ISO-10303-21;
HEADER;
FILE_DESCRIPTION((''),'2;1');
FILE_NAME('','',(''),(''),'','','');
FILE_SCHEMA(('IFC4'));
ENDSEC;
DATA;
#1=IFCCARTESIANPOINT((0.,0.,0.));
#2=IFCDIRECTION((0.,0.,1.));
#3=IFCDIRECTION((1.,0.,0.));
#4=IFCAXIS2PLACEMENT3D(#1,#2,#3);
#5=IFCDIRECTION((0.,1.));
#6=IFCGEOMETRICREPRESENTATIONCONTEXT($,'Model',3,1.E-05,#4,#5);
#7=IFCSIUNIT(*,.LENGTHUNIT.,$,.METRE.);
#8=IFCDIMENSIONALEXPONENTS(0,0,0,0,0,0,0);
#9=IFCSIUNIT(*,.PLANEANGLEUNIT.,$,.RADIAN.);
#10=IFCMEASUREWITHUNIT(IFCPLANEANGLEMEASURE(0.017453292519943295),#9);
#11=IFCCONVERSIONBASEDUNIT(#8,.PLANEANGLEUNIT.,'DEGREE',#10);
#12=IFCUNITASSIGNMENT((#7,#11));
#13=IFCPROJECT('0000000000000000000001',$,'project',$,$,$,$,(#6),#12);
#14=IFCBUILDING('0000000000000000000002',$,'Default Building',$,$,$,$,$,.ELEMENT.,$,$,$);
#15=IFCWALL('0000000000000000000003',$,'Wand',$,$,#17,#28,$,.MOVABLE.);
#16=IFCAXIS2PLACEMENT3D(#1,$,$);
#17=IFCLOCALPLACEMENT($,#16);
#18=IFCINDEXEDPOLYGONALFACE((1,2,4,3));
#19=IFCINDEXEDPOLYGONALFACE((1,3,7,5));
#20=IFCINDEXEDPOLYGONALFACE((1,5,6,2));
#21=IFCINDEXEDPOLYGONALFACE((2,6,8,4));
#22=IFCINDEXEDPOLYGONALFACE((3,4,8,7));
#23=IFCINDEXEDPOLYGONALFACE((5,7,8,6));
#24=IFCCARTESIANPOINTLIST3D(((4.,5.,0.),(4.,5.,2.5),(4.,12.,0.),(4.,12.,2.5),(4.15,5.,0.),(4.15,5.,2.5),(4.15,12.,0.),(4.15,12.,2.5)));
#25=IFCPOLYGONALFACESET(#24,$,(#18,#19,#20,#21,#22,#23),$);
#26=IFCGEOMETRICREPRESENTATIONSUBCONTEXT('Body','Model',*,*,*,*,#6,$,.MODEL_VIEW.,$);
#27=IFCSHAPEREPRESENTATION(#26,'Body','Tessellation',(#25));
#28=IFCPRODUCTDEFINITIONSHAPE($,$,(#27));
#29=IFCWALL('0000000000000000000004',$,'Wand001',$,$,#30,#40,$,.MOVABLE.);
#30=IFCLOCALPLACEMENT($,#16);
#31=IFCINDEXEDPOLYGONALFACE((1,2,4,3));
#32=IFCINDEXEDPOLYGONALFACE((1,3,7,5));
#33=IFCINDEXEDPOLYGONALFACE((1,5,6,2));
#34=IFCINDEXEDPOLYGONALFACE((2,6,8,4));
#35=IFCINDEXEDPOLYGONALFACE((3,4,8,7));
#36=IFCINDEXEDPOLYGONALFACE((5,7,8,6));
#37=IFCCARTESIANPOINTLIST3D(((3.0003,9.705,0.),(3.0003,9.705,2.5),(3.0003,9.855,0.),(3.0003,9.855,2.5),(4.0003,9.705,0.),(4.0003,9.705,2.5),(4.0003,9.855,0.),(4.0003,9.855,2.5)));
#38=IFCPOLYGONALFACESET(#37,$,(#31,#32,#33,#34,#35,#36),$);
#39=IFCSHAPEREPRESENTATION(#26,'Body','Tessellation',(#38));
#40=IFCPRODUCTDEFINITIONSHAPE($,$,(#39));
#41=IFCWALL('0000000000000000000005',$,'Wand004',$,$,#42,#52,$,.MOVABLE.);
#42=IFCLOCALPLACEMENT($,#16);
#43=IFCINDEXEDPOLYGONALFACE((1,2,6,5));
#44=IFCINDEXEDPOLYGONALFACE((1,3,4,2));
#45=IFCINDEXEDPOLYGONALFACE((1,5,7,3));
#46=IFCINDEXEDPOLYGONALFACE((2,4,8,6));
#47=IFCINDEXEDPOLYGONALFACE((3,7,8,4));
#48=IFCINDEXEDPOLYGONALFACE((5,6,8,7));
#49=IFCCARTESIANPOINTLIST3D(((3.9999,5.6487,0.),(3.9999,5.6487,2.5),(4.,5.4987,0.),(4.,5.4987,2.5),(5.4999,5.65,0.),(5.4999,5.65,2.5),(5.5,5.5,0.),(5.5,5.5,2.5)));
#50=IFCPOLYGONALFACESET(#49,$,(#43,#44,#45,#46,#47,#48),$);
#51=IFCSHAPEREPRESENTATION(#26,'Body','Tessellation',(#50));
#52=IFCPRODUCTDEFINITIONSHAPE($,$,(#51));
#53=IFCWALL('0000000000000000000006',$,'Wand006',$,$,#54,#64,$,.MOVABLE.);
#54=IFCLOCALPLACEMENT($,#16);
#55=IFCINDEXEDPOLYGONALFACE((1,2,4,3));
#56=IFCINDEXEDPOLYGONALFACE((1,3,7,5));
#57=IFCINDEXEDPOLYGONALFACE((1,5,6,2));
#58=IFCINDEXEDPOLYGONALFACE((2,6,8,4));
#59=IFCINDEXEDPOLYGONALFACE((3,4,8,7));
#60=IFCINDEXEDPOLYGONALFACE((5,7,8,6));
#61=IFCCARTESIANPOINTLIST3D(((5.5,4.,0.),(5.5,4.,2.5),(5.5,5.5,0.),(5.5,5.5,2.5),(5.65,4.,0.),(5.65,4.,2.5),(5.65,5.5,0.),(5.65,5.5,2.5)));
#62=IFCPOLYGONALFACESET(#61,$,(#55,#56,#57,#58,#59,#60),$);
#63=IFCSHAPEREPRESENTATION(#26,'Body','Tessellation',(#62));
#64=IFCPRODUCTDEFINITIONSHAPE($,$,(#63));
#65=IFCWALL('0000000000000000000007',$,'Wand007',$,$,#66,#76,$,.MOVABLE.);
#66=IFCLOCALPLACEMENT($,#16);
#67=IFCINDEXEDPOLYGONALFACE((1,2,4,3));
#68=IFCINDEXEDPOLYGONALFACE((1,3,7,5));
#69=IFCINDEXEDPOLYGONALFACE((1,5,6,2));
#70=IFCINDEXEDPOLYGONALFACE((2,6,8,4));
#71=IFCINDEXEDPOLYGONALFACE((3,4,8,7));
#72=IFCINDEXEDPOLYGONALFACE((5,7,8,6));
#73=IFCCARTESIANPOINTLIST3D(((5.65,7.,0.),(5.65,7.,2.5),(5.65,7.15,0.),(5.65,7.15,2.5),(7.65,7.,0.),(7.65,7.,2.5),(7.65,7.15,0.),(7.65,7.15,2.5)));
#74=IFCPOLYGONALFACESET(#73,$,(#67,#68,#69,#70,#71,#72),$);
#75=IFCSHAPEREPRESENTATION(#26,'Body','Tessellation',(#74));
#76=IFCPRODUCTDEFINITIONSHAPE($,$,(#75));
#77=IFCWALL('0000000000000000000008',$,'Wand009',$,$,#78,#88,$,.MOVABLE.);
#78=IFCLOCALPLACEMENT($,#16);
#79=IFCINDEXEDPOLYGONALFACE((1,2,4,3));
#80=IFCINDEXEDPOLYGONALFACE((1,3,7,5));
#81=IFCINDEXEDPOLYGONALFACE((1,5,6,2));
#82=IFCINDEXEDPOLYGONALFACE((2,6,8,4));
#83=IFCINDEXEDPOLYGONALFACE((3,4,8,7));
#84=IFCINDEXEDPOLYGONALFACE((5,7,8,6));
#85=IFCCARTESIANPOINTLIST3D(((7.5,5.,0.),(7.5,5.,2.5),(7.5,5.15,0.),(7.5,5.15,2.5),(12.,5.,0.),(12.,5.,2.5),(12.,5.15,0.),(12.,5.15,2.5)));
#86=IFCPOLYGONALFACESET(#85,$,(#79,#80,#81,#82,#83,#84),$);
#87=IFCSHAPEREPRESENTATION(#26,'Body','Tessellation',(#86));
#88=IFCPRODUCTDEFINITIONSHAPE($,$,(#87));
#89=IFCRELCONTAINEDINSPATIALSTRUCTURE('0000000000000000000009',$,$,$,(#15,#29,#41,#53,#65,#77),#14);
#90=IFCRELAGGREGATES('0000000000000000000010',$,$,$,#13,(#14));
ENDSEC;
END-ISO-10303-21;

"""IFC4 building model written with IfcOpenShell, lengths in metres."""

from ifc_helpers import new_model, entity, si_unit, converted_unit, direction, frame, frame_2d, origin_with_axes, origin_2d_with_axis, place, context, subcontext, project, spatial, rectangle, extrude, element, save


model = new_model("IFC4")

# Units and contexts
model_context = context("Model", 3, precision=1e-05, world=origin_with_axes(), true_north=direction((0.0, 1.0)))
body_context = subcontext(model_context, "Body", "Model", "MODEL_VIEW")
ifc_project = project(units=[si_unit("LENGTHUNIT", "METRE"), converted_unit("PLANEANGLEUNIT", "DEGREE", entity("IfcPlaneAngleMeasure", 0.017453292519943295), si_unit("PLANEANGLEUNIT", "RADIAN"), dimensions=[0, 0, 0, 0, 0, 0, 0])], contexts=[model_context])

# Building
building = spatial("IfcBuilding", under=ifc_project, Name="Default Building", CompositionType="ELEMENT")

# Walls
placement = place(None, origin_with_axes())
element("IfcWall", 1, at=placement, inside=building, Name="Wand", PredefinedType="MOVABLE", context=body_context, shape_type="SweptSolid", body=[
    extrude(rectangle(XDim=7.0, YDim=0.15, at=frame_2d((0.0, 0.0), x_axis=(0.0, -1.0))), frame((4.075, 8.5, 0.0), z_axis=(0.0, 0.0, 1.0), x_axis=(1.0, 0.0, 0.0)), (0.0, 0.0, 1.0), 2.5),
])
element("IfcWall", 2, at=placement, inside=building, Name="Wand001", PredefinedType="MOVABLE", context=body_context, shape_type="SweptSolid", body=[
    extrude(rectangle(XDim=1.0, YDim=0.15, at=origin_2d_with_axis()), frame((3.5003, 9.78, 0.0), z_axis=(0.0, 0.0, 1.0), x_axis=(1.0, 0.0, 0.0)), (0.0, 0.0, 1.0), 2.5),
])
element("IfcWall", 3, at=placement, inside=building, Name="Wand004", PredefinedType="MOVABLE", context=body_context, shape_type="SweptSolid", body=[
    extrude(rectangle(XDim=1.5, YDim=0.15, at=frame_2d((0.0, 0.0), x_axis=(1.0, 0.000843))), frame((4.7499, 5.5744, 0.0), z_axis=(0.0, 0.0, 1.0), x_axis=(1.0, 0.0, 0.0)), (0.0, 0.0, 1.0), 2.5),
])
element("IfcWall", 4, at=placement, inside=building, Name="Wand006", PredefinedType="MOVABLE", context=body_context, shape_type="SweptSolid", body=[
    extrude(rectangle(XDim=1.5, YDim=0.15, at=frame_2d((0.0, 0.0), x_axis=(0.0, -1.0))), frame((5.575, 4.75, 0.0), z_axis=(0.0, 0.0, 1.0), x_axis=(1.0, 0.0, 0.0)), (0.0, 0.0, 1.0), 2.5),
])
element("IfcWall", 5, at=placement, inside=building, Name="Wand007", PredefinedType="MOVABLE", context=body_context, shape_type="SweptSolid", body=[
    extrude(rectangle(XDim=2.0, YDim=0.15, at=origin_2d_with_axis()), frame((6.65, 7.075, 0.0), z_axis=(0.0, 0.0, 1.0), x_axis=(1.0, 0.0, 0.0)), (0.0, 0.0, 1.0), 2.5),
])
element("IfcWall", 6, at=placement, inside=building, Name="Wand009", PredefinedType="MOVABLE", context=body_context, shape_type="SweptSolid", body=[
    extrude(rectangle(XDim=4.5, YDim=0.15, at=origin_2d_with_axis()), frame((9.75, 5.075, 0.0), z_axis=(0.0, 0.0, 1.0), x_axis=(1.0, 0.0, 0.0)), (0.0, 0.0, 1.0), 2.5),
])

save(model, "model.ifc")
